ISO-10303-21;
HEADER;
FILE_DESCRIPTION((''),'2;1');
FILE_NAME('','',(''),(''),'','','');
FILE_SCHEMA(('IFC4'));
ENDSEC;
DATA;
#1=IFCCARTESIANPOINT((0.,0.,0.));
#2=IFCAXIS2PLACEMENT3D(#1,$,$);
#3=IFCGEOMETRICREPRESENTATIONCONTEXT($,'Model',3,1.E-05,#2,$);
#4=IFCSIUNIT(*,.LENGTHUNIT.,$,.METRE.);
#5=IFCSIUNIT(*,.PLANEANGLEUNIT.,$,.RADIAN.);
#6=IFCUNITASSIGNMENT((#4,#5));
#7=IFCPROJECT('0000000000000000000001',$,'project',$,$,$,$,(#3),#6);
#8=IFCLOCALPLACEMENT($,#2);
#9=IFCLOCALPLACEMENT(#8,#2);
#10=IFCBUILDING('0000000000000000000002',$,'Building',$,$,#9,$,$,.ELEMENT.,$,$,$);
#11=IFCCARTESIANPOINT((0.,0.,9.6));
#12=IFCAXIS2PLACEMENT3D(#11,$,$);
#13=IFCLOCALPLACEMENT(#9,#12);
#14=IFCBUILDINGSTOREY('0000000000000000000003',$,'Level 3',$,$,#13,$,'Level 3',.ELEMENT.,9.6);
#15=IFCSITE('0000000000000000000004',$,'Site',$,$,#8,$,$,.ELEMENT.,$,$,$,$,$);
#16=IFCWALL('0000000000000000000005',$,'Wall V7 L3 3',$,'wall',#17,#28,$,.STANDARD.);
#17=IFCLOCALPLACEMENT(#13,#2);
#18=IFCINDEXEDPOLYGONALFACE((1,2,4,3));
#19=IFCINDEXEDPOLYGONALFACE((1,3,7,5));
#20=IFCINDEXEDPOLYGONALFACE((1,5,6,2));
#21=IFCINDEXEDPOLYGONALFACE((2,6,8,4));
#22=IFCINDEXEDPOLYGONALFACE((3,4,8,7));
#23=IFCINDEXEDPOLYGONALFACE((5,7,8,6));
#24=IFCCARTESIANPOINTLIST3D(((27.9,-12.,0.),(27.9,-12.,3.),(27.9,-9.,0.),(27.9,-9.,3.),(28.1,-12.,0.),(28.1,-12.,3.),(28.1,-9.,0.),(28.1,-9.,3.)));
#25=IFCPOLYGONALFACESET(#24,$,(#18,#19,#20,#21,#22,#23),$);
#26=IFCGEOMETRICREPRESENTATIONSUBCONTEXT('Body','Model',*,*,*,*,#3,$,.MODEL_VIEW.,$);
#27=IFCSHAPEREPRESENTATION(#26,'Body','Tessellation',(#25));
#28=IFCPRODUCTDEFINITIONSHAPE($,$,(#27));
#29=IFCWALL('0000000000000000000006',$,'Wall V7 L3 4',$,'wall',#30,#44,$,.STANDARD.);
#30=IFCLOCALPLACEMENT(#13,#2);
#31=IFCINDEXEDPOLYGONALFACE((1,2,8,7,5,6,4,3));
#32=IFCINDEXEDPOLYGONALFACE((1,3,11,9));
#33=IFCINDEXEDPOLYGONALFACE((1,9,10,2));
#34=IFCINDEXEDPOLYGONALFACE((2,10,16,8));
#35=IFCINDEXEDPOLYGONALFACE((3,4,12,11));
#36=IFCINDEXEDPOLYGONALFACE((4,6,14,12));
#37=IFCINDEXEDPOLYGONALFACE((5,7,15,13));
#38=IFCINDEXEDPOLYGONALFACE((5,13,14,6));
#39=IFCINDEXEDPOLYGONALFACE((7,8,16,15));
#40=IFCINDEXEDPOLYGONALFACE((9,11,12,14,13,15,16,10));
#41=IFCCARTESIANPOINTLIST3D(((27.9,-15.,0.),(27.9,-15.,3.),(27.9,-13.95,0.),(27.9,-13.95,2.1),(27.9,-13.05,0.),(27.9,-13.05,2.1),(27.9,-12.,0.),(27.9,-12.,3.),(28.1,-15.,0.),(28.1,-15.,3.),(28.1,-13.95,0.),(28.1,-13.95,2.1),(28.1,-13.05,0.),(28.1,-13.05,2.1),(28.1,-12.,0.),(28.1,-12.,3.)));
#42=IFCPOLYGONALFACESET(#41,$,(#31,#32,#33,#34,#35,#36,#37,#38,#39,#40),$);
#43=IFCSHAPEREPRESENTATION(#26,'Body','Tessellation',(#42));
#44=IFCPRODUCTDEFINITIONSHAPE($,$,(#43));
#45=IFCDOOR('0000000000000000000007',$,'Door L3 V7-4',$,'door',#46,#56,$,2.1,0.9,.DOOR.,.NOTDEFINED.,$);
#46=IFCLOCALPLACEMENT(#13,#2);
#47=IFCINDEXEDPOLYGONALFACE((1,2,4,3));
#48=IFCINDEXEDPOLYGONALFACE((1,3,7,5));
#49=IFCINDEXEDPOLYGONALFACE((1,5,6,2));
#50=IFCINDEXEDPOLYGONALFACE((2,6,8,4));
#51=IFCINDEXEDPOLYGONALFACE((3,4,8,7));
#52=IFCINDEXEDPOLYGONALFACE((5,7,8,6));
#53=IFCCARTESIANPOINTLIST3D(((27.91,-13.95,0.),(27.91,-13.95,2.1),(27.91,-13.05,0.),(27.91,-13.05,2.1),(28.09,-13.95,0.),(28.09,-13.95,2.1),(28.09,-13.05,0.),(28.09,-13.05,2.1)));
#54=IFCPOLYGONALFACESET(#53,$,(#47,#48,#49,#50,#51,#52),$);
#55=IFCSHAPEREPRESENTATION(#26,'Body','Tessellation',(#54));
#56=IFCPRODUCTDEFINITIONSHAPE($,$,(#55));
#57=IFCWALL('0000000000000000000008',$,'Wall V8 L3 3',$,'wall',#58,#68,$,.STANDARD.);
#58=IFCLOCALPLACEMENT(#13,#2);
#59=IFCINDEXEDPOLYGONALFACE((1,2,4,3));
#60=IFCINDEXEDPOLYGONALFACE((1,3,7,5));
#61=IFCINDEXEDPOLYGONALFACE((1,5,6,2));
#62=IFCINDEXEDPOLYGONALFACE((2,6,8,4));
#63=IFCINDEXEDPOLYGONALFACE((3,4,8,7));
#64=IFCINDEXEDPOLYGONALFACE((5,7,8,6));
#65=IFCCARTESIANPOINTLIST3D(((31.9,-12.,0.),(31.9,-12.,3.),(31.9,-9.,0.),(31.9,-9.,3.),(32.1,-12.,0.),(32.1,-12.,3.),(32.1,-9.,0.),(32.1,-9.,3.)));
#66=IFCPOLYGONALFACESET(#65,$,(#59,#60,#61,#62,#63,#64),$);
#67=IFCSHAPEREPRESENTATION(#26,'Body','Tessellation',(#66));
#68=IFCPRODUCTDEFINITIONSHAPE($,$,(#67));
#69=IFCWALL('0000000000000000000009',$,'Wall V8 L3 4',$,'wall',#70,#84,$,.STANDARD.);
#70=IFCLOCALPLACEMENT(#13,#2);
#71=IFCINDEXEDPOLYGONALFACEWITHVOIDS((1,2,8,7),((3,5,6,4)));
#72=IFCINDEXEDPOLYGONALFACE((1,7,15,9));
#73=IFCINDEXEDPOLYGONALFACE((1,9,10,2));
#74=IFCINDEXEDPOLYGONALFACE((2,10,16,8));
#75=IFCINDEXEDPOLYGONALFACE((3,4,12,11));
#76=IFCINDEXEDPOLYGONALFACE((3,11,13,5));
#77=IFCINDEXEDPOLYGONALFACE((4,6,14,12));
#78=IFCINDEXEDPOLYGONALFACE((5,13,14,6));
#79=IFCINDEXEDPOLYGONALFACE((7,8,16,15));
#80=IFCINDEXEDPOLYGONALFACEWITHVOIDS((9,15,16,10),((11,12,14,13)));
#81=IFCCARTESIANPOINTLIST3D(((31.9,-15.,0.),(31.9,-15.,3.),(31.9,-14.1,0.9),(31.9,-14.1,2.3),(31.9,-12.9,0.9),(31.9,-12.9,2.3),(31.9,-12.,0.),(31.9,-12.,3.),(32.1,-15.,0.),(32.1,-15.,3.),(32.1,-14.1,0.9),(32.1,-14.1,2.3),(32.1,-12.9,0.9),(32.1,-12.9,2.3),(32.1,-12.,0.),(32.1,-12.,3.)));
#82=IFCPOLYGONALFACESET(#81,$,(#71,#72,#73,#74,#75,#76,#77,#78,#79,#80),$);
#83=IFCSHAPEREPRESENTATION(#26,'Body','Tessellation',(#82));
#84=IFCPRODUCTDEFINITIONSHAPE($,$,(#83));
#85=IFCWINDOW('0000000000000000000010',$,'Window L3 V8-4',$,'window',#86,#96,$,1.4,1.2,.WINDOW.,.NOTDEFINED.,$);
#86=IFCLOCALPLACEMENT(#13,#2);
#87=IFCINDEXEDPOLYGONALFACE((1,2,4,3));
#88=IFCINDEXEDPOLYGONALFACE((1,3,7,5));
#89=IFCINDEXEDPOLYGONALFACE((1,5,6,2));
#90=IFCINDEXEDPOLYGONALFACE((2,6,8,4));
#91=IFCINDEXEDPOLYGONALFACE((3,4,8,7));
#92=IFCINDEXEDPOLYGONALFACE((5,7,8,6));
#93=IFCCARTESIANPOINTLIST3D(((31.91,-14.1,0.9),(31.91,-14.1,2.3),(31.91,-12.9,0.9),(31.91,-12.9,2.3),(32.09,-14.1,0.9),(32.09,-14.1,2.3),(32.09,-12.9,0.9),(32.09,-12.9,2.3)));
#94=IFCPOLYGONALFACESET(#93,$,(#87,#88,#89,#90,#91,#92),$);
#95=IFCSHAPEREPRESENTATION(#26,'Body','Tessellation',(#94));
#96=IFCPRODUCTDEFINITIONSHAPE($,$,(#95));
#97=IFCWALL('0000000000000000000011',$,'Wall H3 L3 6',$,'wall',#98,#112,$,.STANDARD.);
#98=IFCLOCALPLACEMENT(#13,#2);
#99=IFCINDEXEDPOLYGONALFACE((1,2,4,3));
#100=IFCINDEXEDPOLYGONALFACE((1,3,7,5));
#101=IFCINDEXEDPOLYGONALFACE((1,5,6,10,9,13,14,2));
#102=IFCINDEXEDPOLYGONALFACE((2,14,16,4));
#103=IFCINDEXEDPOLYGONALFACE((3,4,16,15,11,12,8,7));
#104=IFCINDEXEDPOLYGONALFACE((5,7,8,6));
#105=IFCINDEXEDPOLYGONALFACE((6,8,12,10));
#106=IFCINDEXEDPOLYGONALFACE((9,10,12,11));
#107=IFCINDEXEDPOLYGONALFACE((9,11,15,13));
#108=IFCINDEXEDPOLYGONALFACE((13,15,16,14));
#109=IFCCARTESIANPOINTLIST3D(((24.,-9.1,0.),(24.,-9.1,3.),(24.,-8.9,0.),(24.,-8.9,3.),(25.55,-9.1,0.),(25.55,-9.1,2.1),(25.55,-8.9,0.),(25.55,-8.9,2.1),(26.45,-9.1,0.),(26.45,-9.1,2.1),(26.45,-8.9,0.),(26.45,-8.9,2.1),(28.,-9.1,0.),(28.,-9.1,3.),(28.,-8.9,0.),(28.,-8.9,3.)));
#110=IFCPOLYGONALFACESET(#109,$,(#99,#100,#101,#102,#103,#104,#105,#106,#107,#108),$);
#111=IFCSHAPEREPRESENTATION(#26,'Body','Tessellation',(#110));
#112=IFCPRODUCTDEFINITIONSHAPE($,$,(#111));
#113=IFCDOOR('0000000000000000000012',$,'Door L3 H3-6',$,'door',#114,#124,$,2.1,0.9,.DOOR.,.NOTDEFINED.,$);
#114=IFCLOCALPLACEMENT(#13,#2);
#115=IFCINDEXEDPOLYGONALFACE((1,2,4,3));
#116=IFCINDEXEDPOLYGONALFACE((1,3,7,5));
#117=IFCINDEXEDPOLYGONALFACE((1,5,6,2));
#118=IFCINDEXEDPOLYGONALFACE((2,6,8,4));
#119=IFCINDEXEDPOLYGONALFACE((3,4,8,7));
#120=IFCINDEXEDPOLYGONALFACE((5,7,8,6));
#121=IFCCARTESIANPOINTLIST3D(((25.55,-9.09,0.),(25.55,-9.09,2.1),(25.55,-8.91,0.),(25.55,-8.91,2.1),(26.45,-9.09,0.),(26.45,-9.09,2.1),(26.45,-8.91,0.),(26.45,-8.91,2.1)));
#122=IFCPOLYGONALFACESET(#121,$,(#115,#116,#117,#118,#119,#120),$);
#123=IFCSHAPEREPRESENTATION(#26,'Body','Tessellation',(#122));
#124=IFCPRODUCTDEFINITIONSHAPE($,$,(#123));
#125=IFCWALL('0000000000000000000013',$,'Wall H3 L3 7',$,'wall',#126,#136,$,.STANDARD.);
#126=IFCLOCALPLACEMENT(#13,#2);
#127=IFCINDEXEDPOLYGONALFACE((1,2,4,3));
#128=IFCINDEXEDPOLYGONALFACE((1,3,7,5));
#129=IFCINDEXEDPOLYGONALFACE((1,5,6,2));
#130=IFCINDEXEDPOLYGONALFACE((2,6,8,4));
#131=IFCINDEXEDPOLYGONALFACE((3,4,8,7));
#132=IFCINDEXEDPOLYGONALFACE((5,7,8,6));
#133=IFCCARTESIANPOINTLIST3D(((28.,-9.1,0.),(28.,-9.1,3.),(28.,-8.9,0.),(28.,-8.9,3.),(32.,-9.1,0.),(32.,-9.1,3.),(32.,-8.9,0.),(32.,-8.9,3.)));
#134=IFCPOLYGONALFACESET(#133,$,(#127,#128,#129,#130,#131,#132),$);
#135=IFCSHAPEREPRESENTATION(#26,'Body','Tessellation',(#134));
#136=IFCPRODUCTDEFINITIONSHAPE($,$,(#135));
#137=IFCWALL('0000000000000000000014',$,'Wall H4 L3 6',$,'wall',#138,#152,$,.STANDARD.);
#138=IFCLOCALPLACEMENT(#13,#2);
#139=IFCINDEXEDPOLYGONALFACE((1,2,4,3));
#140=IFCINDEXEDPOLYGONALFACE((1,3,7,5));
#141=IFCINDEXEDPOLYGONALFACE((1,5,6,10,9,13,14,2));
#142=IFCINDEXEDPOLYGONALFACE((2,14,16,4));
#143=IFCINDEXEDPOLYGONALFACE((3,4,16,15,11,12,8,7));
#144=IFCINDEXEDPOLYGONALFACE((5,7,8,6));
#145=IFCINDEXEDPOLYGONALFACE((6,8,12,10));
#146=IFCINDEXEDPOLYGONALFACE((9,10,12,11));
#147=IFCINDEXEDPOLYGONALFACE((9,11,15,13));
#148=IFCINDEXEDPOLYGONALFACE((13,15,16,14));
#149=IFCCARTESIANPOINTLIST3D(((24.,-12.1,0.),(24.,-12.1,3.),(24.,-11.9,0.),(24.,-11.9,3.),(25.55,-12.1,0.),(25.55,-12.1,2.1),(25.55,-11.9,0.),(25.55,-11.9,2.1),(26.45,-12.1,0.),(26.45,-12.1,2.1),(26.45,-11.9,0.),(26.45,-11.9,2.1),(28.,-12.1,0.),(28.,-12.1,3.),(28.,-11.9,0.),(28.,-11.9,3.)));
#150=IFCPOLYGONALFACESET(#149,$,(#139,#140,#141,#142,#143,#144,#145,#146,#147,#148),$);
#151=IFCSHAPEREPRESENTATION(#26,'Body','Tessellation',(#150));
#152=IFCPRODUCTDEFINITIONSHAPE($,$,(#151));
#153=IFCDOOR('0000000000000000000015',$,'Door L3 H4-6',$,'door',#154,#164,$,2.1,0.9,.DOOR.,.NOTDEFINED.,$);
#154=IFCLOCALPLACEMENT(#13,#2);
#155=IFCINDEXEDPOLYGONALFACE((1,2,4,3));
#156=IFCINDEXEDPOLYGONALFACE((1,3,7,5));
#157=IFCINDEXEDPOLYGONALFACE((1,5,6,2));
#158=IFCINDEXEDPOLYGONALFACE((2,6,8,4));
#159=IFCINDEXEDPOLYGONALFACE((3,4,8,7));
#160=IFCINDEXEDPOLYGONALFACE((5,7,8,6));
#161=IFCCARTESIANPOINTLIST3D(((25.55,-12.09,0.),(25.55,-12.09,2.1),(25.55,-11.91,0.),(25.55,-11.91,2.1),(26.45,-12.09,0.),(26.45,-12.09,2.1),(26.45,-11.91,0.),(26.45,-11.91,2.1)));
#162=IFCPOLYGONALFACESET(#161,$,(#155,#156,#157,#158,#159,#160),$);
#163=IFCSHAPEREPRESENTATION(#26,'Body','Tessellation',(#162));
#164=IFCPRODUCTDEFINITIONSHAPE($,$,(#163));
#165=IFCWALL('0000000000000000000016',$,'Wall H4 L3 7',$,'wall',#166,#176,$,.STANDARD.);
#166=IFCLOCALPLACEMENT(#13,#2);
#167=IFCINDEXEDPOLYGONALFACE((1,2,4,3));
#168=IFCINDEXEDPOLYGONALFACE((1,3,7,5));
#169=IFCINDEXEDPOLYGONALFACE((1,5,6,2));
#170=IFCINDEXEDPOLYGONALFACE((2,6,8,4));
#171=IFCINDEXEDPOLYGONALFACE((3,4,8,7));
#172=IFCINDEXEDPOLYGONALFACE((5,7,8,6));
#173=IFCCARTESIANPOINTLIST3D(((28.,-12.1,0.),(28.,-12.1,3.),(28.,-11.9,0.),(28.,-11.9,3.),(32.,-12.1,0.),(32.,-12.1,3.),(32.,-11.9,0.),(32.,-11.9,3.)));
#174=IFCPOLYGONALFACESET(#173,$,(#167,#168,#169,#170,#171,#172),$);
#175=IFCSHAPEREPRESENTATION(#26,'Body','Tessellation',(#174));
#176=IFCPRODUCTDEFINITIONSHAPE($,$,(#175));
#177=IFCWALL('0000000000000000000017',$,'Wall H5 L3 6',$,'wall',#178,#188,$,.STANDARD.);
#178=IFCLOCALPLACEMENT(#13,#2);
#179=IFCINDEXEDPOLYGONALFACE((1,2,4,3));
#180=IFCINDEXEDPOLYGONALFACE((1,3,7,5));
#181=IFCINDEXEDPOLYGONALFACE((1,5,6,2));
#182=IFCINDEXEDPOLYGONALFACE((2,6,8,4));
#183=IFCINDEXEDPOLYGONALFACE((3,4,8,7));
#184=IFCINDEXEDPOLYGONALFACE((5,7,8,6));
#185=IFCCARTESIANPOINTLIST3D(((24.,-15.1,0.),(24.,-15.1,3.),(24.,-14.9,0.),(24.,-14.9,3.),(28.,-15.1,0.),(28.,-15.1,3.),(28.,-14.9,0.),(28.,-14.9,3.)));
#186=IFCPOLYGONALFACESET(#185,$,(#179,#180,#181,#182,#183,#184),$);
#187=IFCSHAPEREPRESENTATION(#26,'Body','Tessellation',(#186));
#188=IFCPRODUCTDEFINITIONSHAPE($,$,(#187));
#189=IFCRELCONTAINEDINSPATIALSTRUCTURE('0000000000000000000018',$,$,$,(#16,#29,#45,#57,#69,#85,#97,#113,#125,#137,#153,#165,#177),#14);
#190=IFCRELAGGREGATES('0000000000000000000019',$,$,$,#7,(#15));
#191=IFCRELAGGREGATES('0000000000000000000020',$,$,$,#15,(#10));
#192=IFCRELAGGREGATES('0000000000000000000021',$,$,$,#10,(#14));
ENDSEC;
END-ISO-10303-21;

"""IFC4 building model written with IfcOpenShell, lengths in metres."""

from ifc_helpers import new_model, si_unit, frame, frame_2d, origin, origin_2d, place, context, subcontext, project, spatial, rectangle, extrude, element, fill, save


model = new_model("IFC4")

# Units and contexts
model_context = context("Model", 3, precision=1e-05, world=origin())
body_context = subcontext(model_context, "Body", "Model", "MODEL_VIEW")
ifc_project = project(units=[si_unit("LENGTHUNIT", "METRE"), si_unit("PLANEANGLEUNIT", "RADIAN")], contexts=[model_context])

# Site, building, storey
site_placement = place(None, origin())
site = spatial("IfcSite", under=ifc_project, at=site_placement, Name="Site", CompositionType="ELEMENT")
building_placement = place(site_placement, origin())
building = spatial("IfcBuilding", under=site, at=building_placement, Name="Building", CompositionType="ELEMENT")
storey_placement = place(building_placement, frame((0.0, 0.0, 9.6)))
storey = spatial("IfcBuildingStorey", under=building, at=storey_placement, Name="Level 3", LongName="Level 3", CompositionType="ELEMENT", Elevation=9.6)

# Wall
wall_1_placement = place(storey_placement, frame((28.0, -9.0, 0.0), z_axis=(0.0, 0.0, 1.0), x_axis=(0.0, -1.0, 0.0)))
element("IfcWall", 1, at=wall_1_placement, inside=storey, Name="Wall V7 L3 3", ObjectType="wall", PredefinedType="STANDARD", context=body_context, shape_type="SweptSolid", body=[
    extrude(rectangle(XDim=3.0, YDim=0.2, at=frame_2d((1.5, 0.0))), origin(), (0.0, 0.0, 1.0), 3.0),
])

# Wall, opening, door
wall_2_placement = place(storey_placement, frame((28.0, -12.0, 0.0), z_axis=(0.0, 0.0, 1.0), x_axis=(0.0, -1.0, 0.0)))
wall_2 = element("IfcWall", 2, at=wall_2_placement, inside=storey, Name="Wall V7 L3 4", ObjectType="wall", PredefinedType="STANDARD", context=body_context, shape_type="SweptSolid", body=[
    extrude(rectangle(XDim=3.0, YDim=0.2, at=frame_2d((1.5, 0.0))), origin(), (0.0, 0.0, 1.0), 3.0),
])
opening_1_placement = place(storey_placement, frame((28.0, -13.5, 0.0), z_axis=(0.0, 0.0, 1.0), x_axis=(0.0, -1.0, 0.0)))
opening_1 = element("IfcOpeningElement", 3, at=opening_1_placement, cuts=wall_2, ObjectType="Opening", PredefinedType="OPENING", context=body_context, shape_type="SweptSolid", body=[
    extrude(rectangle(XDim=0.9, YDim=0.22, at=origin_2d()), origin(), (0.0, 0.0, 1.0), 2.1),
])
door_1_placement = place(storey_placement, frame((28.0, -13.5, 0.0), z_axis=(0.0, 0.0, 1.0), x_axis=(0.0, -1.0, 0.0)))
door_1 = element("IfcDoor", 4, at=door_1_placement, inside=storey, Name="Door L3 V7-4", ObjectType="door", OperationType="NOTDEFINED", OverallHeight=2.1, OverallWidth=0.9, PredefinedType="DOOR", context=body_context, shape_type="SweptSolid", body=[
    extrude(rectangle(XDim=0.9, YDim=0.18, at=origin_2d()), origin(), (0.0, 0.0, 1.0), 2.1),
])
fill(opening_1, door_1)

# Wall
wall_3_placement = place(storey_placement, frame((32.0, -9.0, 0.0), z_axis=(0.0, 0.0, 1.0), x_axis=(0.0, -1.0, 0.0)))
element("IfcWall", 5, at=wall_3_placement, inside=storey, Name="Wall V8 L3 3", ObjectType="wall", PredefinedType="STANDARD", context=body_context, shape_type="SweptSolid", body=[
    extrude(rectangle(XDim=3.0, YDim=0.2, at=frame_2d((1.5, 0.0))), origin(), (0.0, 0.0, 1.0), 3.0),
])

# Wall, opening, window
wall_4_placement = place(storey_placement, frame((32.0, -12.0, 0.0), z_axis=(0.0, 0.0, 1.0), x_axis=(0.0, -1.0, 0.0)))
wall_4 = element("IfcWall", 6, at=wall_4_placement, inside=storey, Name="Wall V8 L3 4", ObjectType="wall", PredefinedType="STANDARD", context=body_context, shape_type="SweptSolid", body=[
    extrude(rectangle(XDim=3.0, YDim=0.2, at=frame_2d((1.5, 0.0))), origin(), (0.0, 0.0, 1.0), 3.0),
])
opening_2_placement = place(storey_placement, frame((32.0, -13.5, 0.9), z_axis=(0.0, 0.0, 1.0), x_axis=(0.0, -1.0, 0.0)))
opening_2 = element("IfcOpeningElement", 7, at=opening_2_placement, cuts=wall_4, ObjectType="Opening", PredefinedType="OPENING", context=body_context, shape_type="SweptSolid", body=[
    extrude(rectangle(XDim=1.2, YDim=0.22, at=origin_2d()), origin(), (0.0, 0.0, 1.0), 1.4),
])
window_1_placement = place(storey_placement, frame((32.0, -13.5, 0.9), z_axis=(0.0, 0.0, 1.0), x_axis=(0.0, -1.0, 0.0)))
window_1 = element("IfcWindow", 8, at=window_1_placement, inside=storey, Name="Window L3 V8-4", ObjectType="window", OverallHeight=1.4, OverallWidth=1.2, PartitioningType="NOTDEFINED", PredefinedType="WINDOW", context=body_context, shape_type="SweptSolid", body=[
    extrude(rectangle(XDim=1.2, YDim=0.18, at=origin_2d()), origin(), (0.0, 0.0, 1.0), 1.4),
])
fill(opening_2, window_1)

# Wall, opening, door
wall_5_placement = place(storey_placement, frame((24.0, -9.0, 0.0), z_axis=(0.0, 0.0, 1.0), x_axis=(1.0, 0.0, 0.0)))
wall_5 = element("IfcWall", 9, at=wall_5_placement, inside=storey, Name="Wall H3 L3 6", ObjectType="wall", PredefinedType="STANDARD", context=body_context, shape_type="SweptSolid", body=[
    extrude(rectangle(XDim=4.0, YDim=0.2, at=frame_2d((2.0, 0.0))), origin(), (0.0, 0.0, 1.0), 3.0),
])
opening_3_placement = place(storey_placement, frame((26.0, -9.0, 0.0), z_axis=(0.0, 0.0, 1.0), x_axis=(1.0, 0.0, 0.0)))
opening_3 = element("IfcOpeningElement", 10, at=opening_3_placement, cuts=wall_5, ObjectType="Opening", PredefinedType="OPENING", context=body_context, shape_type="SweptSolid", body=[
    extrude(rectangle(XDim=0.9, YDim=0.22, at=origin_2d()), origin(), (0.0, 0.0, 1.0), 2.1),
])
door_2_placement = place(storey_placement, frame((26.0, -9.0, 0.0), z_axis=(0.0, 0.0, 1.0), x_axis=(1.0, 0.0, 0.0)))
door_2 = element("IfcDoor", 11, at=door_2_placement, inside=storey, Name="Door L3 H3-6", ObjectType="door", OperationType="NOTDEFINED", OverallHeight=2.1, OverallWidth=0.9, PredefinedType="DOOR", context=body_context, shape_type="SweptSolid", body=[
    extrude(rectangle(XDim=0.9, YDim=0.18, at=origin_2d()), origin(), (0.0, 0.0, 1.0), 2.1),
])
fill(opening_3, door_2)

# Wall
wall_6_placement = place(storey_placement, frame((28.0, -9.0, 0.0), z_axis=(0.0, 0.0, 1.0), x_axis=(1.0, 0.0, 0.0)))
element("IfcWall", 12, at=wall_6_placement, inside=storey, Name="Wall H3 L3 7", ObjectType="wall", PredefinedType="STANDARD", context=body_context, shape_type="SweptSolid", body=[
    extrude(rectangle(XDim=4.0, YDim=0.2, at=frame_2d((2.0, 0.0))), origin(), (0.0, 0.0, 1.0), 3.0),
])

# Wall, opening, door
wall_7_placement = place(storey_placement, frame((24.0, -12.0, 0.0), z_axis=(0.0, 0.0, 1.0), x_axis=(1.0, 0.0, 0.0)))
wall_7 = element("IfcWall", 13, at=wall_7_placement, inside=storey, Name="Wall H4 L3 6", ObjectType="wall", PredefinedType="STANDARD", context=body_context, shape_type="SweptSolid", body=[
    extrude(rectangle(XDim=4.0, YDim=0.2, at=frame_2d((2.0, 0.0))), origin(), (0.0, 0.0, 1.0), 3.0),
])
opening_4_placement = place(storey_placement, frame((26.0, -12.0, 0.0), z_axis=(0.0, 0.0, 1.0), x_axis=(1.0, 0.0, 0.0)))
opening_4 = element("IfcOpeningElement", 14, at=opening_4_placement, cuts=wall_7, ObjectType="Opening", PredefinedType="OPENING", context=body_context, shape_type="SweptSolid", body=[
    extrude(rectangle(XDim=0.9, YDim=0.22, at=origin_2d()), origin(), (0.0, 0.0, 1.0), 2.1),
])
door_3_placement = place(storey_placement, frame((26.0, -12.0, 0.0), z_axis=(0.0, 0.0, 1.0), x_axis=(1.0, 0.0, 0.0)))
door_3 = element("IfcDoor", 15, at=door_3_placement, inside=storey, Name="Door L3 H4-6", ObjectType="door", OperationType="NOTDEFINED", OverallHeight=2.1, OverallWidth=0.9, PredefinedType="DOOR", context=body_context, shape_type="SweptSolid", body=[
    extrude(rectangle(XDim=0.9, YDim=0.18, at=origin_2d()), origin(), (0.0, 0.0, 1.0), 2.1),
])
fill(opening_4, door_3)

# Walls
for number, where, z_axis, x_axis, name in (
    (16, (28.0, -12.0, 0.0), (0.0, 0.0, 1.0), (1.0, 0.0, 0.0), "Wall H4 L3 7"),
    (17, (24.0, -15.0, 0.0), (0.0, 0.0, 1.0), (1.0, 0.0, 0.0), "Wall H5 L3 6"),
):
    element("IfcWall", number, at=place(storey_placement, frame(where, z_axis=z_axis, x_axis=x_axis)), inside=storey, Name=name, ObjectType="wall", PredefinedType="STANDARD", context=body_context, shape_type="SweptSolid", body=[
        extrude(rectangle(XDim=4.0, YDim=0.2, at=frame_2d((2.0, 0.0))), origin(), (0.0, 0.0, 1.0), 3.0),
    ])

save(model, "model.ifc")
